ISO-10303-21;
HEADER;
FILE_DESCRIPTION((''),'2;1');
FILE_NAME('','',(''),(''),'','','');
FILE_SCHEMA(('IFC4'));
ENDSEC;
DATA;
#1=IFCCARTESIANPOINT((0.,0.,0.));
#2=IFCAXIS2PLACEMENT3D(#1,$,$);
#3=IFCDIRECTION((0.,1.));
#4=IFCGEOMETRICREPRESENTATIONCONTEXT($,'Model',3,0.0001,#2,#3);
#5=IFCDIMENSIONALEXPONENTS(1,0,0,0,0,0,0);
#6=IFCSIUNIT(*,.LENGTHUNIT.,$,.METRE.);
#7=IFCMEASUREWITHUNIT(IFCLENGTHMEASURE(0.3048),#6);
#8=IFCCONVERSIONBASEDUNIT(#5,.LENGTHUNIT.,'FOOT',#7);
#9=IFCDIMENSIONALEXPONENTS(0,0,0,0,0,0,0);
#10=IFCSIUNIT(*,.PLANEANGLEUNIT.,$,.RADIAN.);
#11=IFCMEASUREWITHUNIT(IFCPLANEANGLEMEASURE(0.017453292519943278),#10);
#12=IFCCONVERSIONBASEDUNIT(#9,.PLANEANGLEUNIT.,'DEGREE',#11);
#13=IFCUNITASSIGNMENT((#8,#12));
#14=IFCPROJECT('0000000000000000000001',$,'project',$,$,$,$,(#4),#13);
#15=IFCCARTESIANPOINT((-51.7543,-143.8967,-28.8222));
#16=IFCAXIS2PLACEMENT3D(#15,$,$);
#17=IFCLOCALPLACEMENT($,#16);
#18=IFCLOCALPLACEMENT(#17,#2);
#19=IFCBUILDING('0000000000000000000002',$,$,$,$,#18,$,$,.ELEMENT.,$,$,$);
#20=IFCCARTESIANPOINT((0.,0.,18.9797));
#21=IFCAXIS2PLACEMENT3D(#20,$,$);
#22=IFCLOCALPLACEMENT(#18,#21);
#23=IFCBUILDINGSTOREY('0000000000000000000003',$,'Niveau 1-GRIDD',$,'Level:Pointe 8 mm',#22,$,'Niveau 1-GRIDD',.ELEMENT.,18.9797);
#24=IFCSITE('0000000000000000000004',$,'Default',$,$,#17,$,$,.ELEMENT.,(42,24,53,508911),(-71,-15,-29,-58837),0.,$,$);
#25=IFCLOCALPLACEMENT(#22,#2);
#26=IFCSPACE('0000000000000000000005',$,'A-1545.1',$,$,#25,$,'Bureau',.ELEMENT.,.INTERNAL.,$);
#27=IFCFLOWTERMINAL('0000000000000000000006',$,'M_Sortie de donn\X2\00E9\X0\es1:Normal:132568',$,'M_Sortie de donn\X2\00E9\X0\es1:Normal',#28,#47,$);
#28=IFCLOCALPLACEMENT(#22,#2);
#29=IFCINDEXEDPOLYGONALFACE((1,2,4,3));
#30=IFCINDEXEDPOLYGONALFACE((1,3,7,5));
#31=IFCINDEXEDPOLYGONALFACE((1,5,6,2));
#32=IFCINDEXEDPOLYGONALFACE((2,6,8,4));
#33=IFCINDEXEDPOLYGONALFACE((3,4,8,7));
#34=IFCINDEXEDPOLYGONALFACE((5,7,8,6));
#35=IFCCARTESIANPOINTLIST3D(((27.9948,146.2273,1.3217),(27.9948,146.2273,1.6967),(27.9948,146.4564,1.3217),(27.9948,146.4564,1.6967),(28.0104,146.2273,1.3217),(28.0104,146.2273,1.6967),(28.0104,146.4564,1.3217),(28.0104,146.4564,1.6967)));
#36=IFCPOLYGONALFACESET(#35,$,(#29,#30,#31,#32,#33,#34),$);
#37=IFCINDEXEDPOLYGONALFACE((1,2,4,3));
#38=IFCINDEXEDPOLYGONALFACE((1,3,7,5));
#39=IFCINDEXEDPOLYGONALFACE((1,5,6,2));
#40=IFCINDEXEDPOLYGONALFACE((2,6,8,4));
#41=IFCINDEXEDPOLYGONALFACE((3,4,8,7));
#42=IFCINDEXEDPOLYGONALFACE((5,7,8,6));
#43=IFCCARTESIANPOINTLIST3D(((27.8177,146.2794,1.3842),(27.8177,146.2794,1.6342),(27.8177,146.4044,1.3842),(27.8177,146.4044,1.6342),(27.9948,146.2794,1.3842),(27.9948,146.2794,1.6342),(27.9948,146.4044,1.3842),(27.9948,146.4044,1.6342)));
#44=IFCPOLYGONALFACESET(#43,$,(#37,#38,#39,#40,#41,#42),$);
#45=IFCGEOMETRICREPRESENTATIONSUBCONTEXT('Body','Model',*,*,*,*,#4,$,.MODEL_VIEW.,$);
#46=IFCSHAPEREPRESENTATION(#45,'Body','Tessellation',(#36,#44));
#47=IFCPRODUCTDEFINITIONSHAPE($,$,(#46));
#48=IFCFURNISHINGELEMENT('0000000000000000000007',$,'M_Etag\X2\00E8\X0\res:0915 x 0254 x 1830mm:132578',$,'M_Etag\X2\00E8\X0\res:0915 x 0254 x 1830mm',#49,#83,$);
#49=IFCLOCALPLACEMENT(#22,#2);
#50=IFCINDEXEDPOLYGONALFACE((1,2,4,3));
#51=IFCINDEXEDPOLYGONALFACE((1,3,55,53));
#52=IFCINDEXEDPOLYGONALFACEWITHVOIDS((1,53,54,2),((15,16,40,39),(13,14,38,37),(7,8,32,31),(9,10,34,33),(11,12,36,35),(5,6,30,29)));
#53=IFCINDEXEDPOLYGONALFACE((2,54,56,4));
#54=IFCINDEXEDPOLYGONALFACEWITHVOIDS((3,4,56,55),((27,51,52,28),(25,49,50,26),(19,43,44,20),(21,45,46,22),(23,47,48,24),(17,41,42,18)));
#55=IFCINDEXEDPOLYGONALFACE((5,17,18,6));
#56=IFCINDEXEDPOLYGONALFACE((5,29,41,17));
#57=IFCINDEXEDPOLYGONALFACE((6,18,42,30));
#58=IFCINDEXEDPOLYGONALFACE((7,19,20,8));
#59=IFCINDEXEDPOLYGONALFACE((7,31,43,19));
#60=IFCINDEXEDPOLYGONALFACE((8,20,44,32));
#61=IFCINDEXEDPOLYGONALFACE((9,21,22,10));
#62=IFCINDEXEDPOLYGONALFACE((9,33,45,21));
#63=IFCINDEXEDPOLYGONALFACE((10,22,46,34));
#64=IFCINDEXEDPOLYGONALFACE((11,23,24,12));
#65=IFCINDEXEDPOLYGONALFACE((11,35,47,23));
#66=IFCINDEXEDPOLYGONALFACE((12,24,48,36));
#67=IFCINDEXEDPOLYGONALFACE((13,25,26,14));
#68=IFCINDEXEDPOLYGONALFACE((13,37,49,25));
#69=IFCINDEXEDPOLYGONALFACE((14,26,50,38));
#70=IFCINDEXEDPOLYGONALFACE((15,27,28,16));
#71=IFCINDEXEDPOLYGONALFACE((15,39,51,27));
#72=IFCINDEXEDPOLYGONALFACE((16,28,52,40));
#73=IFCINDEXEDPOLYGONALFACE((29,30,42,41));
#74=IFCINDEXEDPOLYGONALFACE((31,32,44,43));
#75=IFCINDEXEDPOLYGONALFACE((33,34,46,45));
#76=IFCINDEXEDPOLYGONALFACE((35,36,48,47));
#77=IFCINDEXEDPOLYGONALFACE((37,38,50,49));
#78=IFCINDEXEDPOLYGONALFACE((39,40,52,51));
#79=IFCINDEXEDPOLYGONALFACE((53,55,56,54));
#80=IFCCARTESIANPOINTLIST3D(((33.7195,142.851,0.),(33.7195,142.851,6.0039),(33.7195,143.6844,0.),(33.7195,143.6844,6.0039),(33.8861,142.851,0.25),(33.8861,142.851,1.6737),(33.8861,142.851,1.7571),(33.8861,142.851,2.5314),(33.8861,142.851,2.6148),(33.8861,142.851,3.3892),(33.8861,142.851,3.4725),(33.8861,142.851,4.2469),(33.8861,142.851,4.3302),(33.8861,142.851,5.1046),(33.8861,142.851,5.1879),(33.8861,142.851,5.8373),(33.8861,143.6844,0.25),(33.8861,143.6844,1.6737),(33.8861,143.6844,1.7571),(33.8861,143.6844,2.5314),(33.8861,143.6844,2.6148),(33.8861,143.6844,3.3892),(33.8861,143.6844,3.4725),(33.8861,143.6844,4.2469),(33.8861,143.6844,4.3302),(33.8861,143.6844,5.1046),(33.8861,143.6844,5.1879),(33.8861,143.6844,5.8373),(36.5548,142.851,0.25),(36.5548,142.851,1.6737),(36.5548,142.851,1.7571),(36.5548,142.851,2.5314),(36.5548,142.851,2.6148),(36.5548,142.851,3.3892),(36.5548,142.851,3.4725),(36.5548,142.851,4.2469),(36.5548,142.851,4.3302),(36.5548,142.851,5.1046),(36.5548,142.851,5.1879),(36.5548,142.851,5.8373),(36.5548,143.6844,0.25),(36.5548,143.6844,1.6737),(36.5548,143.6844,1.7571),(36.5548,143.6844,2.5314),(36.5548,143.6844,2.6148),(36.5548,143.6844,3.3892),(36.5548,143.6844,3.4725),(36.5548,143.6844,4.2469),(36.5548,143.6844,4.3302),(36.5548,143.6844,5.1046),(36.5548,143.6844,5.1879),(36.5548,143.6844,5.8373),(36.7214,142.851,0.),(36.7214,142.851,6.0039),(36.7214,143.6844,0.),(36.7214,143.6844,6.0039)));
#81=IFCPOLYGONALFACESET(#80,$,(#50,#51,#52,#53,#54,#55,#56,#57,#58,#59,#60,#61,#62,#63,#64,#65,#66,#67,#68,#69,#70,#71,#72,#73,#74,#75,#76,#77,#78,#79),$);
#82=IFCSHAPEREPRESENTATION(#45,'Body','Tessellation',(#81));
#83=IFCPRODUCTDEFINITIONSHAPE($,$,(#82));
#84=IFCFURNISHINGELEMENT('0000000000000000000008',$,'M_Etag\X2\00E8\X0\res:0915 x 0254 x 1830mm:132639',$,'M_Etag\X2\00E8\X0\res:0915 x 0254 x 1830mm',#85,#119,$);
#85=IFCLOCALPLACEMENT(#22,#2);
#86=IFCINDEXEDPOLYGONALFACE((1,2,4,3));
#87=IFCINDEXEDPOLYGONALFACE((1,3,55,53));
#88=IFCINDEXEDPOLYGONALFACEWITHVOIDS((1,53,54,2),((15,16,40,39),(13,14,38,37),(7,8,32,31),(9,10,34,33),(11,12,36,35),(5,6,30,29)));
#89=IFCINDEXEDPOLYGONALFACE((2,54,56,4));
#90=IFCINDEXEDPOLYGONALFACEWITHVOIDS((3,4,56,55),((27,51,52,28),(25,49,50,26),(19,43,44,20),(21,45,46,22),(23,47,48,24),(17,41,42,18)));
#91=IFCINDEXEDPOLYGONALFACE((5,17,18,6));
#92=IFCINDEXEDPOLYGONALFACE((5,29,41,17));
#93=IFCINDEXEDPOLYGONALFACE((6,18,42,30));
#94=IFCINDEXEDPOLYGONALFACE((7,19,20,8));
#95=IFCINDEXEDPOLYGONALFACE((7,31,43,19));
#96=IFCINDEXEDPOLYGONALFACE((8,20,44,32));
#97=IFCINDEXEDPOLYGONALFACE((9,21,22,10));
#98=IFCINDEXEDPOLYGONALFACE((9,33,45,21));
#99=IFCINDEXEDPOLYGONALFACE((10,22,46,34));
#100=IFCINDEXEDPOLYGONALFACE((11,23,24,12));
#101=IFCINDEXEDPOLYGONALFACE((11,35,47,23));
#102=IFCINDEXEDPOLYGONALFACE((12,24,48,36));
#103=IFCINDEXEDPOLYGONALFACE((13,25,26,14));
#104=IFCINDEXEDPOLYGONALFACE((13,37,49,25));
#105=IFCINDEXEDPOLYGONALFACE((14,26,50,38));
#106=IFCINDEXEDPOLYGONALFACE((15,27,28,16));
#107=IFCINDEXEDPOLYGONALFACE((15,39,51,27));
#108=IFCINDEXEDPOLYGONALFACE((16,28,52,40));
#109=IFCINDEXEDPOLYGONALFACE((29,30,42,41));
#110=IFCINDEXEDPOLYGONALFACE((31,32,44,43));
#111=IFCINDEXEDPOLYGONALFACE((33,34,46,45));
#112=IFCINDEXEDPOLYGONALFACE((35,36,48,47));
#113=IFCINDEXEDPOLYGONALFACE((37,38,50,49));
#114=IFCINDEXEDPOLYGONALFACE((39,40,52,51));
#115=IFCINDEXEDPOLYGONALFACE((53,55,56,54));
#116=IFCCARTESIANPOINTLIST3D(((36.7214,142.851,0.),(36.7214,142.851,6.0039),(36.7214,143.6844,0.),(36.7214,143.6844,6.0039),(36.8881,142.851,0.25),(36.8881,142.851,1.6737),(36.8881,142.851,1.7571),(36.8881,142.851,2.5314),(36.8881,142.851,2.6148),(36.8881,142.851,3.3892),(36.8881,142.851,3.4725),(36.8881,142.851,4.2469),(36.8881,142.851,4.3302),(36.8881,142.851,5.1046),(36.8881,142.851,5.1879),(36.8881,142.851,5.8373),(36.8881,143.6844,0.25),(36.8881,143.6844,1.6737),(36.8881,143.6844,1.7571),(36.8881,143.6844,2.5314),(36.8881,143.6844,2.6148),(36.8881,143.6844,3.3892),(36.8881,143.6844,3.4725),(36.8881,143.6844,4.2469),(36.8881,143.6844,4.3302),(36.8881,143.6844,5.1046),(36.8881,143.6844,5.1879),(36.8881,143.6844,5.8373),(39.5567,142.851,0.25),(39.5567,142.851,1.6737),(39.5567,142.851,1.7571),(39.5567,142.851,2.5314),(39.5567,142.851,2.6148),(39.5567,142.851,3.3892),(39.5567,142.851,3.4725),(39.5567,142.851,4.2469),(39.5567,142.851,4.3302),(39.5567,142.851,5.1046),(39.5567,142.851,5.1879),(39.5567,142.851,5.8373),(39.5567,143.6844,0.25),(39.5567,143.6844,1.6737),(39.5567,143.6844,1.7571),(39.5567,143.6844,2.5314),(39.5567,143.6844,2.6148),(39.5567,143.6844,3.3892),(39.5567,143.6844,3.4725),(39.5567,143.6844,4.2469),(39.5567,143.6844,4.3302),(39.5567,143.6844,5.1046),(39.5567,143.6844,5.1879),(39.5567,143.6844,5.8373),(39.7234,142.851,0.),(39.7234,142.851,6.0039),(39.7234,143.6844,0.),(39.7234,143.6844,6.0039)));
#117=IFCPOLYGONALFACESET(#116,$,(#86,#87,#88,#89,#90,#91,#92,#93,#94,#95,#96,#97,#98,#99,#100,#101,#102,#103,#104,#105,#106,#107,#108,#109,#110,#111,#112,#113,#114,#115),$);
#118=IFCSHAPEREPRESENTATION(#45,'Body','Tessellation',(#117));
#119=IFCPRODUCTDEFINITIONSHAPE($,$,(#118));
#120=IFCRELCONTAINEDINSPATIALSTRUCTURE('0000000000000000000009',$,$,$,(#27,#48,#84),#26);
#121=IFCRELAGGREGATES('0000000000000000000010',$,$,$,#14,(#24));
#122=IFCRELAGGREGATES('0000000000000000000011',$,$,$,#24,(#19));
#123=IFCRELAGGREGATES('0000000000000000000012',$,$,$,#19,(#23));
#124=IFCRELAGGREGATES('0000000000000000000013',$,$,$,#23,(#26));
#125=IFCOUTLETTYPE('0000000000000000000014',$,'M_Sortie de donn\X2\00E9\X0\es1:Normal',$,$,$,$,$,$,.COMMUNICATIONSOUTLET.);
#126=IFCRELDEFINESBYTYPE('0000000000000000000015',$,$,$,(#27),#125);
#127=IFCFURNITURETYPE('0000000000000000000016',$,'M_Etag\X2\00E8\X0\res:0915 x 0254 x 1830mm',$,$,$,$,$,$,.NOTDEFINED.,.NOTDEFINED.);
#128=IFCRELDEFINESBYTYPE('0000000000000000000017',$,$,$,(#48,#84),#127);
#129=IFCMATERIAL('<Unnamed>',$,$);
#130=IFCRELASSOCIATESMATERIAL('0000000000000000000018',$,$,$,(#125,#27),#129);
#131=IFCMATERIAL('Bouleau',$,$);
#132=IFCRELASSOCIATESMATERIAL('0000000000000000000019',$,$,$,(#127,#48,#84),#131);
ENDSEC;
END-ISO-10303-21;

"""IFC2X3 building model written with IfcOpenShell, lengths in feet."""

from ifc_helpers import new_model, entity, si_unit, converted_unit, direction, frame, frame_2d, origin, place, context, subcontext, project, spatial, polyline, rectangle, outline, extrude, source, transform, mapped, material, type_object, type_shapes, element, save


model = new_model("IFC2X3")

# Units and contexts
model_context = context("Model", 3, precision=0.0001, world=origin(), true_north=direction((0.0, 1.0)))
body_context = subcontext(model_context, "Body", "Model", "MODEL_VIEW")
ifc_project = project(units=[converted_unit("LENGTHUNIT", "FOOT", entity("IfcLengthMeasure", 0.3048), si_unit("LENGTHUNIT", "METRE"), dimensions=[1, 0, 0, 0, 0, 0, 0]), converted_unit("PLANEANGLEUNIT", "DEGREE", entity("IfcPlaneAngleMeasure", 0.017453292519943278), si_unit("PLANEANGLEUNIT", "RADIAN"), dimensions=[0, 0, 0, 0, 0, 0, 0])], contexts=[model_context])

# Site, building, storey
site_placement = place(None, frame((-51.7543, -143.8967, -28.8222)))
site = spatial("IfcSite", under=ifc_project, at=site_placement, Name="Default", CompositionType="ELEMENT", RefLatitude=(42, 24, 53, 508911), RefLongitude=(-71, -15, -29, -58837), RefElevation=0.0)
building_placement = place(site_placement, origin())
building = spatial("IfcBuilding", under=site, at=building_placement, CompositionType="ELEMENT")
storey_placement = place(building_placement, frame((0.0, 0.0, 18.9797)))
storey = spatial("IfcBuildingStorey", under=building, at=storey_placement, Name="Niveau 1-GRIDD", ObjectType="Level:Pointe 8 mm", LongName="Niveau 1-GRIDD", CompositionType="ELEMENT", Elevation=18.9797)

# Shared definitions
ifc_material_1 = material(Name="<Unnamed>")
outlet_type = type_object("IfcOutletType", Name="M_Sortie de données1:Normal", PredefinedType="COMMUNICATIONSOUTLET", material=ifc_material_1)
shared_shape_1 = source(origin(), body_context, "Body", "SweptSolid", [
    extrude(rectangle(XDim=0.2292, YDim=0.375, at=frame_2d((0.0, 0.0), x_axis=(1.0, 0.0))), frame((0.0, 0.0, 0.0), z_axis=(0.0, 0.0, 1.0), x_axis=(-1.0, 0.0, 0.0)), (0.0, 0.0, 1.0), 0.0156),
    extrude(rectangle(XDim=0.125, YDim=0.25, at=frame_2d((0.0, 0.0), x_axis=(1.0, 0.0))), frame((0.0, 0.0, -0.1771), z_axis=(0.0, 0.0, 1.0), x_axis=(-1.0, 0.0, 0.0)), (0.0, 0.0, 1.0), 0.1771),
])
type_shapes(outlet_type, [shared_shape_1])

# Shared definitions
space_1_placement = place(storey_placement, origin())
space_1 = spatial("IfcSpace", under=storey, at=space_1_placement, Name="A-1545.1", LongName="Bureau", CompositionType="ELEMENT", InteriorOrExteriorSpace="INTERNAL")

# Flow terminal
flow_terminal_1_placement = place(space_1_placement, frame((27.9948, 146.3419, 1.5092), z_axis=(1.0, 0.0, 0.0), x_axis=(0.0, 1.0, 0.0)))
element("IfcFlowTerminal", 1, at=flow_terminal_1_placement, inside=space_1, type_object=outlet_type, material=ifc_material_1, Name="M_Sortie de données1:Normal:132568", ObjectType="M_Sortie de données1:Normal", context=body_context, shape_type="MappedRepresentation", body=[
    mapped(shared_shape_1, transform((0.0, 0.0, 0.0), scale=1.0)),
])

# Furnishing elements
ifc_material_2 = material(Name="Bouleau")
furniture_type_1 = type_object("IfcFurnitureType", Name="M_Etagères:0915 x 0254 x 1830mm", AssemblyPlace="NOTDEFINED", material=ifc_material_2)
shared_shape_2 = source(origin(), body_context, "Body", "SweptSolid", [
    extrude(outline(polyline([(-1.501, -3.002), (1.501, -3.002), (1.501, 3.002), (-1.501, 3.002), (-1.501, -3.002)]), holes=[polyline([(-1.3343, 2.8353), (1.3343, 2.8353), (1.3343, 2.1859), (-1.3343, 2.1859), (-1.3343, 2.8353)]), polyline([(-1.3343, -2.752), (-1.3343, -1.3282), (1.3343, -1.3282), (1.3343, -2.752), (-1.3343, -2.752)]), polyline([(1.3343, 0.4705), (-1.3343, 0.4705), (-1.3343, 1.2449), (1.3343, 1.2449), (1.3343, 0.4705)]), polyline([(-1.3343, 2.1026), (1.3343, 2.1026), (1.3343, 1.3282), (-1.3343, 1.3282), (-1.3343, 2.1026)]), polyline([(-1.3343, 0.3872), (1.3343, 0.3872), (1.3343, -0.3872), (-1.3343, -0.3872), (-1.3343, 0.3872)]), polyline([(-1.3343, -0.4705), (1.3343, -0.4705), (1.3343, -1.2449), (-1.3343, -1.2449), (-1.3343, -0.4705)])]), frame((0.0, -1.4167, 3.002), z_axis=(0.0, 1.0, 0.0), x_axis=(-1.0, 0.0, 0.0)), (0.0, 0.0, 1.0), 0.8333),
])
type_shapes(furniture_type_1, [shared_shape_2])
for number, where, name in (
    (2, (35.2204, 144.2677, 0.0), "M_Etagères:0915 x 0254 x 1830mm:132578"),
    (3, (38.2224, 144.2677, 0.0), "M_Etagères:0915 x 0254 x 1830mm:132639"),
):
    element("IfcFurnishingElement", number, at=place(space_1_placement, frame(where)), inside=space_1, type_object=furniture_type_1, material=ifc_material_2, Name=name, ObjectType="M_Etagères:0915 x 0254 x 1830mm", context=body_context, shape_type="MappedRepresentation", body=[
        mapped(shared_shape_2, transform((0.0, 0.0, 0.0), scale=1.0)),
    ])

save(model, "model.ifc")
